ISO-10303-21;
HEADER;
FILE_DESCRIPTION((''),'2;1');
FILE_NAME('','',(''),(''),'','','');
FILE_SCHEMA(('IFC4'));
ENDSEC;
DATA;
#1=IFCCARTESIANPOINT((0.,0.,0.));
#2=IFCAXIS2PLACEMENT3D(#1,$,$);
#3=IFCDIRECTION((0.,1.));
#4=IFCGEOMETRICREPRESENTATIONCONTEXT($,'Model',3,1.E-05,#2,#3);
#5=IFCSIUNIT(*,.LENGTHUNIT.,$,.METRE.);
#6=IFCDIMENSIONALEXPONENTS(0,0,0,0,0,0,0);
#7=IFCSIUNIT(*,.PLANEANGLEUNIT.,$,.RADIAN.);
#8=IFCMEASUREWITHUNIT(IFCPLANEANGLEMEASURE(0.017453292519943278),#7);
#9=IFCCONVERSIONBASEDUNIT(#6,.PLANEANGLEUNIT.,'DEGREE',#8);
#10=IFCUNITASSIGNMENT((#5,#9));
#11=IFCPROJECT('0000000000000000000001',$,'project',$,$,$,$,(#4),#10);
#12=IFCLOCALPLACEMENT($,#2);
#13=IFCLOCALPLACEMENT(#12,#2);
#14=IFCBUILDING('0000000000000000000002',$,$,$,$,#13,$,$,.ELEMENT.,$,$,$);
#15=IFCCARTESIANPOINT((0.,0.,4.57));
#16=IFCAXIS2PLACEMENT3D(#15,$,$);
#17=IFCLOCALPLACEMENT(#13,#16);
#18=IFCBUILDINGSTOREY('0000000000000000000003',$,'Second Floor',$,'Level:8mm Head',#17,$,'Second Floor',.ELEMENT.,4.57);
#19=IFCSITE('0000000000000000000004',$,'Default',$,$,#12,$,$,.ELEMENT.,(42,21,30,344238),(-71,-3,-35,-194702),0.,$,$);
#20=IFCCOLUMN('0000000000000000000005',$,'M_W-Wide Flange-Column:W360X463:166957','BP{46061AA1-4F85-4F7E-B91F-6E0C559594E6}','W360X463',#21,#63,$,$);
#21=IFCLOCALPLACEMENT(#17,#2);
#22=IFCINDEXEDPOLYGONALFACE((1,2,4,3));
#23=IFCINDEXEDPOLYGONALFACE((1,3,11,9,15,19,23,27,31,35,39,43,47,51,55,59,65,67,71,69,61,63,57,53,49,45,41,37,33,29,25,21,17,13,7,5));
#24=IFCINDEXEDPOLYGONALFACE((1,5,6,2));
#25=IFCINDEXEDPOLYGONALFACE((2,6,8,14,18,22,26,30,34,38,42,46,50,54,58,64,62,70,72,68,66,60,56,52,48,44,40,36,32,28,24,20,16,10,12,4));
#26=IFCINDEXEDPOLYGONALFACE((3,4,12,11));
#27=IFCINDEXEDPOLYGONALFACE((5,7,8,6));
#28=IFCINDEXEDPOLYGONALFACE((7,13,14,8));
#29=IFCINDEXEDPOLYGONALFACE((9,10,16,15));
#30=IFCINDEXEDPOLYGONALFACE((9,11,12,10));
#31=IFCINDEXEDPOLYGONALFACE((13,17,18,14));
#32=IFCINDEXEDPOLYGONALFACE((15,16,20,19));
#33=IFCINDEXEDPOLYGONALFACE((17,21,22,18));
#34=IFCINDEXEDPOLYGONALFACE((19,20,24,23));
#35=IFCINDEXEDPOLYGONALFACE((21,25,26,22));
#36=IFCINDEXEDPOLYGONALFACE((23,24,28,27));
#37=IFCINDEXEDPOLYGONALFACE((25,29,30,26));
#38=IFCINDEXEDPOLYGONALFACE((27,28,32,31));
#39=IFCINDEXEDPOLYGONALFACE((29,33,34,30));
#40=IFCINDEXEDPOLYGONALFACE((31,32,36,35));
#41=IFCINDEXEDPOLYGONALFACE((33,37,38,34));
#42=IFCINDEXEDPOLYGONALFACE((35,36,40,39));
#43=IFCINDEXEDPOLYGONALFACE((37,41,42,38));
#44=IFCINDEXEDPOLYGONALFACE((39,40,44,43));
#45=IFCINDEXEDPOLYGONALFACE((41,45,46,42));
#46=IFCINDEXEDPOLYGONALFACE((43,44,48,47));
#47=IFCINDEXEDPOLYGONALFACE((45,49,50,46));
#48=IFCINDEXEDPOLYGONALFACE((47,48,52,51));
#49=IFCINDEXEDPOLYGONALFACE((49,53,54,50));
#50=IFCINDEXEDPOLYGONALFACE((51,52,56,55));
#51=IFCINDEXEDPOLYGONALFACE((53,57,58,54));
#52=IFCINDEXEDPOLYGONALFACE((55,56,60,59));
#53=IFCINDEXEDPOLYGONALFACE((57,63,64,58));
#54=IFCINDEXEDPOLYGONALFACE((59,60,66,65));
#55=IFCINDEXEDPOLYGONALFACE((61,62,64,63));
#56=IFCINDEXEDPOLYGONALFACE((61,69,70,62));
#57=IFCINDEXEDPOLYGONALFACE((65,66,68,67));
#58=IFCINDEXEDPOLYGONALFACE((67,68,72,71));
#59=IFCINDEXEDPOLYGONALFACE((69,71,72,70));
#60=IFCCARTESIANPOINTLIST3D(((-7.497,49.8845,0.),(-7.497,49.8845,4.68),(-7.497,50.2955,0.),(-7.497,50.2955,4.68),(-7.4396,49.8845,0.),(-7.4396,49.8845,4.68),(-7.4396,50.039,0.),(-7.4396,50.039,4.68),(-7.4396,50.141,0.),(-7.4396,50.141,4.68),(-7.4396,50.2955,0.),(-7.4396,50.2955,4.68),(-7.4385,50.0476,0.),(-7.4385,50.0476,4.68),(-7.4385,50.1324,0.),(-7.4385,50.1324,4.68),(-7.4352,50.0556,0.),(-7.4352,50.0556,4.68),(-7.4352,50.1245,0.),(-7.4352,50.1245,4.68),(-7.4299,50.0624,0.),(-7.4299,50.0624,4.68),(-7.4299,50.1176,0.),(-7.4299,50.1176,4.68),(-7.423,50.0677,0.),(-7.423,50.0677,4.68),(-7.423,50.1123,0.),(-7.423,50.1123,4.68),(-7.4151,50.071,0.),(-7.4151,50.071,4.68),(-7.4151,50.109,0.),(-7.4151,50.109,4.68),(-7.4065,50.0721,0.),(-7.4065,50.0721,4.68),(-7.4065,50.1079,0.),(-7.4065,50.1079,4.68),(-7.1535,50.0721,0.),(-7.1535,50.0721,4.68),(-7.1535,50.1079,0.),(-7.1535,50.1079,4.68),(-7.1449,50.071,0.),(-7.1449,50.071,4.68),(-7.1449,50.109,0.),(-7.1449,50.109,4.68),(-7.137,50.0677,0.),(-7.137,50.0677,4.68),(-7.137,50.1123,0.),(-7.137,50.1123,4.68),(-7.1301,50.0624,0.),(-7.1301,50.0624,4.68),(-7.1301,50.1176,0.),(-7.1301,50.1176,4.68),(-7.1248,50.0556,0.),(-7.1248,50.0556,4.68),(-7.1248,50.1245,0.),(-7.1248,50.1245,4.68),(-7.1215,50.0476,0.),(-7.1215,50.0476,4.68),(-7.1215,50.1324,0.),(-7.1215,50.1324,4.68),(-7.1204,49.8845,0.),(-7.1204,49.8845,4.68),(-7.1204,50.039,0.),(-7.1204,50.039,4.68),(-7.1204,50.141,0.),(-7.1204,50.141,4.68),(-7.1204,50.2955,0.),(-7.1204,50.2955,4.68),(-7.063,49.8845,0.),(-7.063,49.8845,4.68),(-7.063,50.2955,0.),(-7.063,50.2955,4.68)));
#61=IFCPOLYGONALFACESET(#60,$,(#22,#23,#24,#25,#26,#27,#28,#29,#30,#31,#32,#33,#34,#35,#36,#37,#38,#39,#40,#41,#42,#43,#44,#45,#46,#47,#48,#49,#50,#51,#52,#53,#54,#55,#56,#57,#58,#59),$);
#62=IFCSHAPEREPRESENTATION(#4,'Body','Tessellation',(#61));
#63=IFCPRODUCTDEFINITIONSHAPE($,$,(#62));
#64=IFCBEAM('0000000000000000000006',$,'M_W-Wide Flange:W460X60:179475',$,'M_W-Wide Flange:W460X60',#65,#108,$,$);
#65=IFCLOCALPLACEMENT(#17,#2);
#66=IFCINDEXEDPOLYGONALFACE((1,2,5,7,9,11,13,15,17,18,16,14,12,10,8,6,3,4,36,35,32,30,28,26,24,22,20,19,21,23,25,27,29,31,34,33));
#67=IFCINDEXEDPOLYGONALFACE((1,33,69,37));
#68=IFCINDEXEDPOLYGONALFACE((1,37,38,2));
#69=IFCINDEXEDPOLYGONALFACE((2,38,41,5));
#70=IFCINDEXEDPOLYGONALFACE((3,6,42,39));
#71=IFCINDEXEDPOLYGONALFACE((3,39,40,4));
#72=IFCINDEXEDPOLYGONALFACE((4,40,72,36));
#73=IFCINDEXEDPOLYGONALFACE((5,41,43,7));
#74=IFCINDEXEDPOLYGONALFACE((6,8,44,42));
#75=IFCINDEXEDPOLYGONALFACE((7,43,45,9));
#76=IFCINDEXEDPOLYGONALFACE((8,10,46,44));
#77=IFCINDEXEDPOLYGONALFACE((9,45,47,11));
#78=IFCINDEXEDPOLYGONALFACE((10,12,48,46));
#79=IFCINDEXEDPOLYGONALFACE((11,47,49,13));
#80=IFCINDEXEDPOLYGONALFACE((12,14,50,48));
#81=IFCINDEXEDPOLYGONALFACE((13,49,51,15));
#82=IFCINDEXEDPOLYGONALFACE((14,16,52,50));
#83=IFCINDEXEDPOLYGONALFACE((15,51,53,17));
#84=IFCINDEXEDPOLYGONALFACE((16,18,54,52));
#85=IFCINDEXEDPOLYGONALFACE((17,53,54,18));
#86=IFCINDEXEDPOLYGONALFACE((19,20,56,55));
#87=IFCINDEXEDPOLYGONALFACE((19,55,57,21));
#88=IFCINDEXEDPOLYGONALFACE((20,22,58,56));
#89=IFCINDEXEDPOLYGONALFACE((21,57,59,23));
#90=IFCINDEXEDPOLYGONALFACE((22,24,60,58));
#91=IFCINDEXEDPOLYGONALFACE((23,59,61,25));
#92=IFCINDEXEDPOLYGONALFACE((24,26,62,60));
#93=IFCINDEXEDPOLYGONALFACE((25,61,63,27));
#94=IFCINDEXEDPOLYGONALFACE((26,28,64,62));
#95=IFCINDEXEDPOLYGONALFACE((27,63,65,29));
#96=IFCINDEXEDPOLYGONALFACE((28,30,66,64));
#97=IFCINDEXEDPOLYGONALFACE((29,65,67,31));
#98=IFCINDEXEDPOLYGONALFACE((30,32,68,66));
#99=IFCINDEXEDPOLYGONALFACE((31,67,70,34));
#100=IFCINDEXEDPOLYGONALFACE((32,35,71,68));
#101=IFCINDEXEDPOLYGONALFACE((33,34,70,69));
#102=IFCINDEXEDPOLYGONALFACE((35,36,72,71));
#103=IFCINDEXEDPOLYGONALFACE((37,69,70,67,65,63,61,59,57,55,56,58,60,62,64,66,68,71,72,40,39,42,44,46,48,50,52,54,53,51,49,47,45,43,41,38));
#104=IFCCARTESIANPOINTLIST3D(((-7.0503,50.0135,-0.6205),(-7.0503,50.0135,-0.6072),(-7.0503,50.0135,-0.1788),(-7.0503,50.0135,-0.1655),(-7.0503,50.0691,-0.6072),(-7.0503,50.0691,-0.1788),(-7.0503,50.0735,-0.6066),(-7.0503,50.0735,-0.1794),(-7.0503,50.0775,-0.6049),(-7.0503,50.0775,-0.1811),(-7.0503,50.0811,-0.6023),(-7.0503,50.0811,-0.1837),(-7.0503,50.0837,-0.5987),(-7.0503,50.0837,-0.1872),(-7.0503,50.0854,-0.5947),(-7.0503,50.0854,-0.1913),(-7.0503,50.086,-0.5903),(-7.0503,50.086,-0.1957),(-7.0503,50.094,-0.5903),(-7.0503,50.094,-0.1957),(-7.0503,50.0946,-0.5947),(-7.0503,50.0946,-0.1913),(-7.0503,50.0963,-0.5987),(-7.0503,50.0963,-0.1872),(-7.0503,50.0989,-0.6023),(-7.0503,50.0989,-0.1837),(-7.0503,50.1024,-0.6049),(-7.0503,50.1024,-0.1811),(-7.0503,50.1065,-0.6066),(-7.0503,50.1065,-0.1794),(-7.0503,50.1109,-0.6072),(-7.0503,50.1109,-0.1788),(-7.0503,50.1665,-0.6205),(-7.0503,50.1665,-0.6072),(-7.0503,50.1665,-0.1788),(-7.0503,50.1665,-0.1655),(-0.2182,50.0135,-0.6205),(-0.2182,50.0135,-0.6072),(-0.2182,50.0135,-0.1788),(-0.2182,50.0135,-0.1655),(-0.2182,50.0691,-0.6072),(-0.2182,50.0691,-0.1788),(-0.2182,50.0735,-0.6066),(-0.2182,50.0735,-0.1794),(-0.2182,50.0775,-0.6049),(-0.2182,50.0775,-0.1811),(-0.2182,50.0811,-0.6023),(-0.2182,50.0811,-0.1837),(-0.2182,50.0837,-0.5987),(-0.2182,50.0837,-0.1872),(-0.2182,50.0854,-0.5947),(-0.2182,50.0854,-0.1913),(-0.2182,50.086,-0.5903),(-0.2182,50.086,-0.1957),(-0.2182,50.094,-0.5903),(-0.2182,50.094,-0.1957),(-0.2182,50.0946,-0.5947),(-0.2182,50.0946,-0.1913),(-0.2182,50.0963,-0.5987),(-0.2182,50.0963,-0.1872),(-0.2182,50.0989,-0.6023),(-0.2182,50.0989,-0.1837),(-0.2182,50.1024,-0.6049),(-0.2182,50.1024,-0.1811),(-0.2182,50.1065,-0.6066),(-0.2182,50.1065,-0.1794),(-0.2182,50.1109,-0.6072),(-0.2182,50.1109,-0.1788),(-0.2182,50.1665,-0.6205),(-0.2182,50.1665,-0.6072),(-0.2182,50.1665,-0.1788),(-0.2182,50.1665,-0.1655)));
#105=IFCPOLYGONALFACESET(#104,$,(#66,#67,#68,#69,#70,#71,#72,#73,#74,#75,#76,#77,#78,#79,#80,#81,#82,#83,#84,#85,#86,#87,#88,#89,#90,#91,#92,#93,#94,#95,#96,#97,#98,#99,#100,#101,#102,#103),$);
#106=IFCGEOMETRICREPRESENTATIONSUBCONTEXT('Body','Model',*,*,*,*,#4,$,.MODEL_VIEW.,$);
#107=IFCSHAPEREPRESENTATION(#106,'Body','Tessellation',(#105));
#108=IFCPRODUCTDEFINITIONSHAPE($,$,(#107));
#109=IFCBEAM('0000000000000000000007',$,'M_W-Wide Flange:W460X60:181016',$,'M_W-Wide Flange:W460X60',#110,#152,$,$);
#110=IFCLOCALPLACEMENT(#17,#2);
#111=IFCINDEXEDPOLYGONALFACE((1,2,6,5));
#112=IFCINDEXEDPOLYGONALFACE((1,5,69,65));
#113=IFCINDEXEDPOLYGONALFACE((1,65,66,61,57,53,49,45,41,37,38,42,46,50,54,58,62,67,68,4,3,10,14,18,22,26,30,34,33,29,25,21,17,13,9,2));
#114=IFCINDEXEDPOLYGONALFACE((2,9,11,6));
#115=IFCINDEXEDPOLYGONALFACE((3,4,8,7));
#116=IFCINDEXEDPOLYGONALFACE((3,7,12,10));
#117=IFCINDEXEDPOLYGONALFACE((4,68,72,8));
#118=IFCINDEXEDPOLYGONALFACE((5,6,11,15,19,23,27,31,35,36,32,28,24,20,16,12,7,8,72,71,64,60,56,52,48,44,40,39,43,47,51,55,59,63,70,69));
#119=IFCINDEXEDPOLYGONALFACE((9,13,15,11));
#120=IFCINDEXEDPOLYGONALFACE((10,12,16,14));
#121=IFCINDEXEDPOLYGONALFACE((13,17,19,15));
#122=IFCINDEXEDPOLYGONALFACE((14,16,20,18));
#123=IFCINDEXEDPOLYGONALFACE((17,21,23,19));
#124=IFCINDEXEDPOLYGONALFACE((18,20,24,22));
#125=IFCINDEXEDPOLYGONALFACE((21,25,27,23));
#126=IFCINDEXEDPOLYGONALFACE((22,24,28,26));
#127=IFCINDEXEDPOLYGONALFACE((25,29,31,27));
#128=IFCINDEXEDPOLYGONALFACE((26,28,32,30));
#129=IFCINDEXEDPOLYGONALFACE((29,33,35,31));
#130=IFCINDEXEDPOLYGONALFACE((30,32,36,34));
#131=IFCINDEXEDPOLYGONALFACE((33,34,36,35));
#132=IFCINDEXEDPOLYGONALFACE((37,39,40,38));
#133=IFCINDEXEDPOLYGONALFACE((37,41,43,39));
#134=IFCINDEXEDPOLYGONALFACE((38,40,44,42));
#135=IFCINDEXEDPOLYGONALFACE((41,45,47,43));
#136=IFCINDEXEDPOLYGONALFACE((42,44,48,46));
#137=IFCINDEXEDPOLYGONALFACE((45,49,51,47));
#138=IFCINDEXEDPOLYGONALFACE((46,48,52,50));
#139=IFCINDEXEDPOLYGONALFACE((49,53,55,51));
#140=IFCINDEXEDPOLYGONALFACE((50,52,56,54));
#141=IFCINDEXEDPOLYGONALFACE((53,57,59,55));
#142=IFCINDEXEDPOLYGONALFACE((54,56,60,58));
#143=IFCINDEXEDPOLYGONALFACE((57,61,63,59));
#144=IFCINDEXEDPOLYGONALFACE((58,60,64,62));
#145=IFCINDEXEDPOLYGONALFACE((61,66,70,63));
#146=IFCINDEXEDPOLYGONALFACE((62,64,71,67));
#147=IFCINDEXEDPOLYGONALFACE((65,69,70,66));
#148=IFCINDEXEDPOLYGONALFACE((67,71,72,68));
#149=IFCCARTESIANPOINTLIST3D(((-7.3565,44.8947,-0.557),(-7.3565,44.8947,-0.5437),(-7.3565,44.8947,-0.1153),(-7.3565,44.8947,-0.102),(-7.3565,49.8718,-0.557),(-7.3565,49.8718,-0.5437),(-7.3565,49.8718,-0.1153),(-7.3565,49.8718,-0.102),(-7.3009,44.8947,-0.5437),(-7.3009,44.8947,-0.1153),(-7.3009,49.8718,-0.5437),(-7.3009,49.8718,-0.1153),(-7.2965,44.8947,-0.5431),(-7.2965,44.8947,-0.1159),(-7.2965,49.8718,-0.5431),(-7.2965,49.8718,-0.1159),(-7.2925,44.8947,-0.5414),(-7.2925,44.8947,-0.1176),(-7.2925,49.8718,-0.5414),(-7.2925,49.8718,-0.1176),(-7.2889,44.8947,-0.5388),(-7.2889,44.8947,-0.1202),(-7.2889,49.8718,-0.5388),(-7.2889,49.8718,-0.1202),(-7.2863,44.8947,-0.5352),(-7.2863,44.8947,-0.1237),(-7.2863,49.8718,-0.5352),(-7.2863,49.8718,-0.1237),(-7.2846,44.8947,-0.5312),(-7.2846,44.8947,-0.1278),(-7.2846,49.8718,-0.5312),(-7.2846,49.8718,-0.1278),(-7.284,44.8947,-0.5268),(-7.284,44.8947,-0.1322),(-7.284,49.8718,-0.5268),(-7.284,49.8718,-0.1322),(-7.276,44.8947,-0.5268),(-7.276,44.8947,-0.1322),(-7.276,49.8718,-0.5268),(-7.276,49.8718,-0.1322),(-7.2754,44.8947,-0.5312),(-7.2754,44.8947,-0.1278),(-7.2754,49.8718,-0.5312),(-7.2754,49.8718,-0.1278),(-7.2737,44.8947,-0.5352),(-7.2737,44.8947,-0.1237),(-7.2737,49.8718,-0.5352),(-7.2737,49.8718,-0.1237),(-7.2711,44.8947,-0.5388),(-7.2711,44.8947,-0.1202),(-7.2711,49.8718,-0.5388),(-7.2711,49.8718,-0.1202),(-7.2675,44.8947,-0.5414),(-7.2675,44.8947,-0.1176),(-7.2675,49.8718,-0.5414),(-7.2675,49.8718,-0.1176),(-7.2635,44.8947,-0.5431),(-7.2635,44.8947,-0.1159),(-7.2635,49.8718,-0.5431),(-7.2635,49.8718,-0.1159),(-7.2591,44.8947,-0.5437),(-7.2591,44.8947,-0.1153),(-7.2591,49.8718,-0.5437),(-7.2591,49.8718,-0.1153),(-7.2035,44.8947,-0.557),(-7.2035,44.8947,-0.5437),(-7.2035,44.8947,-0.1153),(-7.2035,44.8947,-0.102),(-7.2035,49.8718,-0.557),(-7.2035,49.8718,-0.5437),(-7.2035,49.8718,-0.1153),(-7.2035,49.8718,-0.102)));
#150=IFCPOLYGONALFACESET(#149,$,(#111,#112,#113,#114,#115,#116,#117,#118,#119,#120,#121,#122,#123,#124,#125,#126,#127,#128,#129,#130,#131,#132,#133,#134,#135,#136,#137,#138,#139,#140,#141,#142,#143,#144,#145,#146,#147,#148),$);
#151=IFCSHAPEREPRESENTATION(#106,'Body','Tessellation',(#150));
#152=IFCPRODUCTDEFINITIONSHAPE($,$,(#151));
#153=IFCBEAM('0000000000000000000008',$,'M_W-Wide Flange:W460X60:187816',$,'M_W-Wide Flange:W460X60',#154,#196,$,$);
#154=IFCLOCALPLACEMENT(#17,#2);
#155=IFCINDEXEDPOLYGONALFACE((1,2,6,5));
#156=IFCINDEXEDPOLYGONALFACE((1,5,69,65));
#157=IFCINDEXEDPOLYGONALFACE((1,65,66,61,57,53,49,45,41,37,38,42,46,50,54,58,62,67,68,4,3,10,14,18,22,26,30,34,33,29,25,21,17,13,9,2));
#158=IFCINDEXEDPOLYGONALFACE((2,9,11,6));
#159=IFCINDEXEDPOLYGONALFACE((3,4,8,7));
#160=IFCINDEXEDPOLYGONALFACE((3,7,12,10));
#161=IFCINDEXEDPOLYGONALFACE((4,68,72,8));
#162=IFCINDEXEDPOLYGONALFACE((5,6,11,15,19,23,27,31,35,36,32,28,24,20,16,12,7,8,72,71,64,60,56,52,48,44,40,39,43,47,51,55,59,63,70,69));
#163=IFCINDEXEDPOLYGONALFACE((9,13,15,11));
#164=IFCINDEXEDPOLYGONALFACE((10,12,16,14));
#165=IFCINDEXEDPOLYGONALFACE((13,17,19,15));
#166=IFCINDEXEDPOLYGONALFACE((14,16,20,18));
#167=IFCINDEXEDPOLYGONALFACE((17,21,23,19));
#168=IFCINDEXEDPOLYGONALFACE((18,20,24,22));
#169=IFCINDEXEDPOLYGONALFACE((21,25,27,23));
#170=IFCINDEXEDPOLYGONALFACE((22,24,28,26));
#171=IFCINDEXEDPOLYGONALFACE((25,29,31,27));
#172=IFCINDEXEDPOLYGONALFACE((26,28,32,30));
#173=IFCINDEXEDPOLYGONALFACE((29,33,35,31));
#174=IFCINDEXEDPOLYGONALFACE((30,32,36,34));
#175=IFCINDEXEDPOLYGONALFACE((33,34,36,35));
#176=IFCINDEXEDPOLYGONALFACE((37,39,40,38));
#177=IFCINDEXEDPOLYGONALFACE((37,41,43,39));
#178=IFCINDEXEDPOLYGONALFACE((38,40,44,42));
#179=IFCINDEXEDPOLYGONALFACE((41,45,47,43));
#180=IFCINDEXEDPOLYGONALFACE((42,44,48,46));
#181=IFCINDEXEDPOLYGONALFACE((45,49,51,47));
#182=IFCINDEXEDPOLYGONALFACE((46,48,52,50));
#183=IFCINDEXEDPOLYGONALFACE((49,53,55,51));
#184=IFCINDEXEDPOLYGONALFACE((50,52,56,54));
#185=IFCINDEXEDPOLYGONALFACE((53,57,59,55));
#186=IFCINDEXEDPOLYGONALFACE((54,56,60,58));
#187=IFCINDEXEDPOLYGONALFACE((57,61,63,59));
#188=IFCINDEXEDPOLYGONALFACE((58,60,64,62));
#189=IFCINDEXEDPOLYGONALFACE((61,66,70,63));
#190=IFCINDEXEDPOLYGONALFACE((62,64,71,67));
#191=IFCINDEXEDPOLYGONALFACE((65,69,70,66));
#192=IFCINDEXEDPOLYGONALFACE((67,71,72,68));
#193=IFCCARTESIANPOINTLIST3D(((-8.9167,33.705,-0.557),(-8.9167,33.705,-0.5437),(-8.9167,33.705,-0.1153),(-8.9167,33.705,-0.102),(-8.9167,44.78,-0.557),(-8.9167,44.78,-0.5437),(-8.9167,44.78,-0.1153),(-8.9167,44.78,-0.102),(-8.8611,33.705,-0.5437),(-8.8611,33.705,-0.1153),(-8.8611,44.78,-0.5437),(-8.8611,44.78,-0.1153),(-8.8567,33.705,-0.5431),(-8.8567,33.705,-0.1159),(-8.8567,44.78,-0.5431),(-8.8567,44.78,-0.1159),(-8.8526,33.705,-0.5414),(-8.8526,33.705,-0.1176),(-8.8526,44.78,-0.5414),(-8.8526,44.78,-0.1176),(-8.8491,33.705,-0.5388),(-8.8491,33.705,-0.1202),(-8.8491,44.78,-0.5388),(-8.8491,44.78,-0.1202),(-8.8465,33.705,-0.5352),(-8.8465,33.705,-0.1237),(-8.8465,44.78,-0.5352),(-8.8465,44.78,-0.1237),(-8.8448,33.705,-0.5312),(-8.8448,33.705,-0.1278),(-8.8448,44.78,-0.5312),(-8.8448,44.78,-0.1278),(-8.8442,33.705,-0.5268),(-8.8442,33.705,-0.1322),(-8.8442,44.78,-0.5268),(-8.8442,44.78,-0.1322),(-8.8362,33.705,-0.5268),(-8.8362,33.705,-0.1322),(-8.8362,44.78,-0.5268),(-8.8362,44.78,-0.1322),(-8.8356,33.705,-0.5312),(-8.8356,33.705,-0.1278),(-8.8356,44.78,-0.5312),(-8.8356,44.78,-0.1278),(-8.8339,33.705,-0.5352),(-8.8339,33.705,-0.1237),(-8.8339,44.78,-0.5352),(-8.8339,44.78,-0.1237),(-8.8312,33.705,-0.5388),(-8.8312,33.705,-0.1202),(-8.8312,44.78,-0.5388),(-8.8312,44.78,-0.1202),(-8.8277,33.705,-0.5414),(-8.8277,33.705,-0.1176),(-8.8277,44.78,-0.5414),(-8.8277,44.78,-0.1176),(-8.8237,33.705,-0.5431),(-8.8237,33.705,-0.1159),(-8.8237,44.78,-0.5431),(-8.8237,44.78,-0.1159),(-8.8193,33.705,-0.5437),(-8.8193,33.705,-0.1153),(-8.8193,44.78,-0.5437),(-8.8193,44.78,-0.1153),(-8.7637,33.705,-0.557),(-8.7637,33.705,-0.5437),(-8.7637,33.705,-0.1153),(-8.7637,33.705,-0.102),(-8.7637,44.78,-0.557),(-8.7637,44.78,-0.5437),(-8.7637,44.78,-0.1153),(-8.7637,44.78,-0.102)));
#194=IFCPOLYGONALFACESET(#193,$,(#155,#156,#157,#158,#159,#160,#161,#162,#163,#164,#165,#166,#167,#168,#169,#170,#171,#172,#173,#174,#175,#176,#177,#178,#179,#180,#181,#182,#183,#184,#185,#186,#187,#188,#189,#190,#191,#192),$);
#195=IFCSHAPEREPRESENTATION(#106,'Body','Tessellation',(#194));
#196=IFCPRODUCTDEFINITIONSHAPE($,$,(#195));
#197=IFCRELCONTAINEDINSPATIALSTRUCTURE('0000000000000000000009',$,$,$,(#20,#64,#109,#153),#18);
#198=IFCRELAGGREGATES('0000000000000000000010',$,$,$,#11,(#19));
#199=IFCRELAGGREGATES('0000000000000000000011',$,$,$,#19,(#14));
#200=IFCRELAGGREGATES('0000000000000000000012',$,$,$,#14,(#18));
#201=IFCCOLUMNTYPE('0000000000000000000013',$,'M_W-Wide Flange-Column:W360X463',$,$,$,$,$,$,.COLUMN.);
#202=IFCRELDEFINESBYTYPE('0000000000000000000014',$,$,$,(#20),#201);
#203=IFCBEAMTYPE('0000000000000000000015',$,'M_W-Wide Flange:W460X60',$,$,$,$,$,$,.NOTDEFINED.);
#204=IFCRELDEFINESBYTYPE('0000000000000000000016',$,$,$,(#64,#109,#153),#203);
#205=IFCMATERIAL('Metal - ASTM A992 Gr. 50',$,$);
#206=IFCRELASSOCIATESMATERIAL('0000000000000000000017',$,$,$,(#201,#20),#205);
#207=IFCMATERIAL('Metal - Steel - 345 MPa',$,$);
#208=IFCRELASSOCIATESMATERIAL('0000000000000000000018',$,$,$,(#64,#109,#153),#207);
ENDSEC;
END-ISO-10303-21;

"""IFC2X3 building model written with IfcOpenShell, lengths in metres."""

from ifc_helpers import new_model, entity, si_unit, converted_unit, direction, frame, frame_2d, origin, origin_2d, place, context, subcontext, project, spatial, i_section, extrude, material, type_object, element, save


model = new_model("IFC2X3")

# Units and contexts
model_context = context("Model", 3, precision=1e-05, world=origin(), true_north=direction((0.0, 1.0)))
body_context = subcontext(model_context, "Body", "Model", "MODEL_VIEW")
ifc_project = project(units=[si_unit("LENGTHUNIT", "METRE"), converted_unit("PLANEANGLEUNIT", "DEGREE", entity("IfcPlaneAngleMeasure", 0.017453292519943278), si_unit("PLANEANGLEUNIT", "RADIAN"), dimensions=[0, 0, 0, 0, 0, 0, 0])], contexts=[model_context])

# Site, building, storey
site_placement = place(None, origin())
site = spatial("IfcSite", under=ifc_project, at=site_placement, Name="Default", CompositionType="ELEMENT", RefLatitude=(42, 21, 30, 344238), RefLongitude=(-71, -3, -35, -194702), RefElevation=0.0)
building_placement = place(site_placement, origin())
building = spatial("IfcBuilding", under=site, at=building_placement, CompositionType="ELEMENT")
storey_placement = place(building_placement, frame((0.0, 0.0, 4.57)))
storey = spatial("IfcBuildingStorey", under=building, at=storey_placement, Name="Second Floor", ObjectType="Level:8mm Head", LongName="Second Floor", CompositionType="ELEMENT", Elevation=4.57)

# Column
ifc_material_1 = material(Name="Metal - ASTM A992 Gr. 50")
column_type = type_object("IfcColumnType", Name="M_W-Wide Flange-Column:W360X463", PredefinedType="COLUMN", material=ifc_material_1)
column_placement = place(storey_placement, frame((-7.28, 50.09, 4.68), z_axis=(0.0, 0.0, 1.0), x_axis=(0.0, 1.0, 0.0)))
element("IfcColumn", 1, at=column_placement, inside=storey, type_object=column_type, material=ifc_material_1, Name="M_W-Wide Flange-Column:W360X463:166957", Description="BP{46061AA1-4F85-4F7E-B91F-6E0C559594E6}", ObjectType="W360X463", context=model_context, shape_type="SweptSolid", body=[
    extrude(i_section(OverallWidth=0.411, OverallDepth=0.434, WebThickness=0.0358, FlangeThickness=0.0574, FilletRadius=0.0331, at=origin_2d()), origin(), (0.0, 0.0, -1.0), 4.68),
])

# Beams
ifc_material_2 = material(Name="Metal - Steel - 345 MPa")
beam_type = type_object("IfcBeamType", Name="M_W-Wide Flange:W460X60", PredefinedType="NOTDEFINED")
beam_1_placement = place(storey_placement, frame((-7.28, 50.09, -0.1655)))
element("IfcBeam", 2, at=beam_1_placement, inside=storey, type_object=beam_type, material=ifc_material_2, Name="M_W-Wide Flange:W460X60:179475", ObjectType="M_W-Wide Flange:W460X60", context=body_context, shape_type="SweptSolid", body=[
    extrude(i_section(OverallWidth=0.153, OverallDepth=0.455, WebThickness=0.008, FlangeThickness=0.0133, FilletRadius=0.0169, at=frame_2d((0.0, 0.0), x_axis=(0.0, 1.0))), frame((0.2297, 0.0, -0.2275), z_axis=(1.0, 0.0, 0.0), x_axis=(0.0, 0.0, -1.0)), (0.0, 0.0, 1.0), 6.8321),
])
beam_2_placement = place(storey_placement, frame((-7.28, 50.09, -0.102), z_axis=(0.0, 0.0, 1.0), x_axis=(0.0, -1.0, 0.0)))
element("IfcBeam", 3, at=beam_2_placement, inside=storey, type_object=beam_type, material=ifc_material_2, Name="M_W-Wide Flange:W460X60:181016", ObjectType="M_W-Wide Flange:W460X60", context=body_context, shape_type="SweptSolid", body=[
    extrude(i_section(OverallWidth=0.153, OverallDepth=0.455, WebThickness=0.008, FlangeThickness=0.0133, FilletRadius=0.0169, at=frame_2d((0.0, 0.0), x_axis=(0.0, 1.0))), frame((0.2182, 0.0, -0.2275), z_axis=(1.0, 0.0, 0.0), x_axis=(0.0, 0.0, -1.0)), (0.0, 0.0, 1.0), 4.9771),
])
beam_3_placement = place(storey_placement, frame((-8.8402, 44.78, -0.102), z_axis=(0.0, 0.0, 1.0), x_axis=(0.0, -1.0, 0.0)))
element("IfcBeam", 4, at=beam_3_placement, inside=storey, type_object=beam_type, material=ifc_material_2, Name="M_W-Wide Flange:W460X60:187816", ObjectType="M_W-Wide Flange:W460X60", context=body_context, shape_type="SweptSolid", body=[
    extrude(i_section(OverallWidth=0.153, OverallDepth=0.455, WebThickness=0.008, FlangeThickness=0.0133, FilletRadius=0.0169, at=frame_2d((0.0, 0.0), x_axis=(0.0, 1.0))), frame((0.0, 0.0, -0.2275), z_axis=(1.0, 0.0, 0.0), x_axis=(0.0, 0.0, -1.0)), (0.0, 0.0, 1.0), 11.075),
])

save(model, "model.ifc")
